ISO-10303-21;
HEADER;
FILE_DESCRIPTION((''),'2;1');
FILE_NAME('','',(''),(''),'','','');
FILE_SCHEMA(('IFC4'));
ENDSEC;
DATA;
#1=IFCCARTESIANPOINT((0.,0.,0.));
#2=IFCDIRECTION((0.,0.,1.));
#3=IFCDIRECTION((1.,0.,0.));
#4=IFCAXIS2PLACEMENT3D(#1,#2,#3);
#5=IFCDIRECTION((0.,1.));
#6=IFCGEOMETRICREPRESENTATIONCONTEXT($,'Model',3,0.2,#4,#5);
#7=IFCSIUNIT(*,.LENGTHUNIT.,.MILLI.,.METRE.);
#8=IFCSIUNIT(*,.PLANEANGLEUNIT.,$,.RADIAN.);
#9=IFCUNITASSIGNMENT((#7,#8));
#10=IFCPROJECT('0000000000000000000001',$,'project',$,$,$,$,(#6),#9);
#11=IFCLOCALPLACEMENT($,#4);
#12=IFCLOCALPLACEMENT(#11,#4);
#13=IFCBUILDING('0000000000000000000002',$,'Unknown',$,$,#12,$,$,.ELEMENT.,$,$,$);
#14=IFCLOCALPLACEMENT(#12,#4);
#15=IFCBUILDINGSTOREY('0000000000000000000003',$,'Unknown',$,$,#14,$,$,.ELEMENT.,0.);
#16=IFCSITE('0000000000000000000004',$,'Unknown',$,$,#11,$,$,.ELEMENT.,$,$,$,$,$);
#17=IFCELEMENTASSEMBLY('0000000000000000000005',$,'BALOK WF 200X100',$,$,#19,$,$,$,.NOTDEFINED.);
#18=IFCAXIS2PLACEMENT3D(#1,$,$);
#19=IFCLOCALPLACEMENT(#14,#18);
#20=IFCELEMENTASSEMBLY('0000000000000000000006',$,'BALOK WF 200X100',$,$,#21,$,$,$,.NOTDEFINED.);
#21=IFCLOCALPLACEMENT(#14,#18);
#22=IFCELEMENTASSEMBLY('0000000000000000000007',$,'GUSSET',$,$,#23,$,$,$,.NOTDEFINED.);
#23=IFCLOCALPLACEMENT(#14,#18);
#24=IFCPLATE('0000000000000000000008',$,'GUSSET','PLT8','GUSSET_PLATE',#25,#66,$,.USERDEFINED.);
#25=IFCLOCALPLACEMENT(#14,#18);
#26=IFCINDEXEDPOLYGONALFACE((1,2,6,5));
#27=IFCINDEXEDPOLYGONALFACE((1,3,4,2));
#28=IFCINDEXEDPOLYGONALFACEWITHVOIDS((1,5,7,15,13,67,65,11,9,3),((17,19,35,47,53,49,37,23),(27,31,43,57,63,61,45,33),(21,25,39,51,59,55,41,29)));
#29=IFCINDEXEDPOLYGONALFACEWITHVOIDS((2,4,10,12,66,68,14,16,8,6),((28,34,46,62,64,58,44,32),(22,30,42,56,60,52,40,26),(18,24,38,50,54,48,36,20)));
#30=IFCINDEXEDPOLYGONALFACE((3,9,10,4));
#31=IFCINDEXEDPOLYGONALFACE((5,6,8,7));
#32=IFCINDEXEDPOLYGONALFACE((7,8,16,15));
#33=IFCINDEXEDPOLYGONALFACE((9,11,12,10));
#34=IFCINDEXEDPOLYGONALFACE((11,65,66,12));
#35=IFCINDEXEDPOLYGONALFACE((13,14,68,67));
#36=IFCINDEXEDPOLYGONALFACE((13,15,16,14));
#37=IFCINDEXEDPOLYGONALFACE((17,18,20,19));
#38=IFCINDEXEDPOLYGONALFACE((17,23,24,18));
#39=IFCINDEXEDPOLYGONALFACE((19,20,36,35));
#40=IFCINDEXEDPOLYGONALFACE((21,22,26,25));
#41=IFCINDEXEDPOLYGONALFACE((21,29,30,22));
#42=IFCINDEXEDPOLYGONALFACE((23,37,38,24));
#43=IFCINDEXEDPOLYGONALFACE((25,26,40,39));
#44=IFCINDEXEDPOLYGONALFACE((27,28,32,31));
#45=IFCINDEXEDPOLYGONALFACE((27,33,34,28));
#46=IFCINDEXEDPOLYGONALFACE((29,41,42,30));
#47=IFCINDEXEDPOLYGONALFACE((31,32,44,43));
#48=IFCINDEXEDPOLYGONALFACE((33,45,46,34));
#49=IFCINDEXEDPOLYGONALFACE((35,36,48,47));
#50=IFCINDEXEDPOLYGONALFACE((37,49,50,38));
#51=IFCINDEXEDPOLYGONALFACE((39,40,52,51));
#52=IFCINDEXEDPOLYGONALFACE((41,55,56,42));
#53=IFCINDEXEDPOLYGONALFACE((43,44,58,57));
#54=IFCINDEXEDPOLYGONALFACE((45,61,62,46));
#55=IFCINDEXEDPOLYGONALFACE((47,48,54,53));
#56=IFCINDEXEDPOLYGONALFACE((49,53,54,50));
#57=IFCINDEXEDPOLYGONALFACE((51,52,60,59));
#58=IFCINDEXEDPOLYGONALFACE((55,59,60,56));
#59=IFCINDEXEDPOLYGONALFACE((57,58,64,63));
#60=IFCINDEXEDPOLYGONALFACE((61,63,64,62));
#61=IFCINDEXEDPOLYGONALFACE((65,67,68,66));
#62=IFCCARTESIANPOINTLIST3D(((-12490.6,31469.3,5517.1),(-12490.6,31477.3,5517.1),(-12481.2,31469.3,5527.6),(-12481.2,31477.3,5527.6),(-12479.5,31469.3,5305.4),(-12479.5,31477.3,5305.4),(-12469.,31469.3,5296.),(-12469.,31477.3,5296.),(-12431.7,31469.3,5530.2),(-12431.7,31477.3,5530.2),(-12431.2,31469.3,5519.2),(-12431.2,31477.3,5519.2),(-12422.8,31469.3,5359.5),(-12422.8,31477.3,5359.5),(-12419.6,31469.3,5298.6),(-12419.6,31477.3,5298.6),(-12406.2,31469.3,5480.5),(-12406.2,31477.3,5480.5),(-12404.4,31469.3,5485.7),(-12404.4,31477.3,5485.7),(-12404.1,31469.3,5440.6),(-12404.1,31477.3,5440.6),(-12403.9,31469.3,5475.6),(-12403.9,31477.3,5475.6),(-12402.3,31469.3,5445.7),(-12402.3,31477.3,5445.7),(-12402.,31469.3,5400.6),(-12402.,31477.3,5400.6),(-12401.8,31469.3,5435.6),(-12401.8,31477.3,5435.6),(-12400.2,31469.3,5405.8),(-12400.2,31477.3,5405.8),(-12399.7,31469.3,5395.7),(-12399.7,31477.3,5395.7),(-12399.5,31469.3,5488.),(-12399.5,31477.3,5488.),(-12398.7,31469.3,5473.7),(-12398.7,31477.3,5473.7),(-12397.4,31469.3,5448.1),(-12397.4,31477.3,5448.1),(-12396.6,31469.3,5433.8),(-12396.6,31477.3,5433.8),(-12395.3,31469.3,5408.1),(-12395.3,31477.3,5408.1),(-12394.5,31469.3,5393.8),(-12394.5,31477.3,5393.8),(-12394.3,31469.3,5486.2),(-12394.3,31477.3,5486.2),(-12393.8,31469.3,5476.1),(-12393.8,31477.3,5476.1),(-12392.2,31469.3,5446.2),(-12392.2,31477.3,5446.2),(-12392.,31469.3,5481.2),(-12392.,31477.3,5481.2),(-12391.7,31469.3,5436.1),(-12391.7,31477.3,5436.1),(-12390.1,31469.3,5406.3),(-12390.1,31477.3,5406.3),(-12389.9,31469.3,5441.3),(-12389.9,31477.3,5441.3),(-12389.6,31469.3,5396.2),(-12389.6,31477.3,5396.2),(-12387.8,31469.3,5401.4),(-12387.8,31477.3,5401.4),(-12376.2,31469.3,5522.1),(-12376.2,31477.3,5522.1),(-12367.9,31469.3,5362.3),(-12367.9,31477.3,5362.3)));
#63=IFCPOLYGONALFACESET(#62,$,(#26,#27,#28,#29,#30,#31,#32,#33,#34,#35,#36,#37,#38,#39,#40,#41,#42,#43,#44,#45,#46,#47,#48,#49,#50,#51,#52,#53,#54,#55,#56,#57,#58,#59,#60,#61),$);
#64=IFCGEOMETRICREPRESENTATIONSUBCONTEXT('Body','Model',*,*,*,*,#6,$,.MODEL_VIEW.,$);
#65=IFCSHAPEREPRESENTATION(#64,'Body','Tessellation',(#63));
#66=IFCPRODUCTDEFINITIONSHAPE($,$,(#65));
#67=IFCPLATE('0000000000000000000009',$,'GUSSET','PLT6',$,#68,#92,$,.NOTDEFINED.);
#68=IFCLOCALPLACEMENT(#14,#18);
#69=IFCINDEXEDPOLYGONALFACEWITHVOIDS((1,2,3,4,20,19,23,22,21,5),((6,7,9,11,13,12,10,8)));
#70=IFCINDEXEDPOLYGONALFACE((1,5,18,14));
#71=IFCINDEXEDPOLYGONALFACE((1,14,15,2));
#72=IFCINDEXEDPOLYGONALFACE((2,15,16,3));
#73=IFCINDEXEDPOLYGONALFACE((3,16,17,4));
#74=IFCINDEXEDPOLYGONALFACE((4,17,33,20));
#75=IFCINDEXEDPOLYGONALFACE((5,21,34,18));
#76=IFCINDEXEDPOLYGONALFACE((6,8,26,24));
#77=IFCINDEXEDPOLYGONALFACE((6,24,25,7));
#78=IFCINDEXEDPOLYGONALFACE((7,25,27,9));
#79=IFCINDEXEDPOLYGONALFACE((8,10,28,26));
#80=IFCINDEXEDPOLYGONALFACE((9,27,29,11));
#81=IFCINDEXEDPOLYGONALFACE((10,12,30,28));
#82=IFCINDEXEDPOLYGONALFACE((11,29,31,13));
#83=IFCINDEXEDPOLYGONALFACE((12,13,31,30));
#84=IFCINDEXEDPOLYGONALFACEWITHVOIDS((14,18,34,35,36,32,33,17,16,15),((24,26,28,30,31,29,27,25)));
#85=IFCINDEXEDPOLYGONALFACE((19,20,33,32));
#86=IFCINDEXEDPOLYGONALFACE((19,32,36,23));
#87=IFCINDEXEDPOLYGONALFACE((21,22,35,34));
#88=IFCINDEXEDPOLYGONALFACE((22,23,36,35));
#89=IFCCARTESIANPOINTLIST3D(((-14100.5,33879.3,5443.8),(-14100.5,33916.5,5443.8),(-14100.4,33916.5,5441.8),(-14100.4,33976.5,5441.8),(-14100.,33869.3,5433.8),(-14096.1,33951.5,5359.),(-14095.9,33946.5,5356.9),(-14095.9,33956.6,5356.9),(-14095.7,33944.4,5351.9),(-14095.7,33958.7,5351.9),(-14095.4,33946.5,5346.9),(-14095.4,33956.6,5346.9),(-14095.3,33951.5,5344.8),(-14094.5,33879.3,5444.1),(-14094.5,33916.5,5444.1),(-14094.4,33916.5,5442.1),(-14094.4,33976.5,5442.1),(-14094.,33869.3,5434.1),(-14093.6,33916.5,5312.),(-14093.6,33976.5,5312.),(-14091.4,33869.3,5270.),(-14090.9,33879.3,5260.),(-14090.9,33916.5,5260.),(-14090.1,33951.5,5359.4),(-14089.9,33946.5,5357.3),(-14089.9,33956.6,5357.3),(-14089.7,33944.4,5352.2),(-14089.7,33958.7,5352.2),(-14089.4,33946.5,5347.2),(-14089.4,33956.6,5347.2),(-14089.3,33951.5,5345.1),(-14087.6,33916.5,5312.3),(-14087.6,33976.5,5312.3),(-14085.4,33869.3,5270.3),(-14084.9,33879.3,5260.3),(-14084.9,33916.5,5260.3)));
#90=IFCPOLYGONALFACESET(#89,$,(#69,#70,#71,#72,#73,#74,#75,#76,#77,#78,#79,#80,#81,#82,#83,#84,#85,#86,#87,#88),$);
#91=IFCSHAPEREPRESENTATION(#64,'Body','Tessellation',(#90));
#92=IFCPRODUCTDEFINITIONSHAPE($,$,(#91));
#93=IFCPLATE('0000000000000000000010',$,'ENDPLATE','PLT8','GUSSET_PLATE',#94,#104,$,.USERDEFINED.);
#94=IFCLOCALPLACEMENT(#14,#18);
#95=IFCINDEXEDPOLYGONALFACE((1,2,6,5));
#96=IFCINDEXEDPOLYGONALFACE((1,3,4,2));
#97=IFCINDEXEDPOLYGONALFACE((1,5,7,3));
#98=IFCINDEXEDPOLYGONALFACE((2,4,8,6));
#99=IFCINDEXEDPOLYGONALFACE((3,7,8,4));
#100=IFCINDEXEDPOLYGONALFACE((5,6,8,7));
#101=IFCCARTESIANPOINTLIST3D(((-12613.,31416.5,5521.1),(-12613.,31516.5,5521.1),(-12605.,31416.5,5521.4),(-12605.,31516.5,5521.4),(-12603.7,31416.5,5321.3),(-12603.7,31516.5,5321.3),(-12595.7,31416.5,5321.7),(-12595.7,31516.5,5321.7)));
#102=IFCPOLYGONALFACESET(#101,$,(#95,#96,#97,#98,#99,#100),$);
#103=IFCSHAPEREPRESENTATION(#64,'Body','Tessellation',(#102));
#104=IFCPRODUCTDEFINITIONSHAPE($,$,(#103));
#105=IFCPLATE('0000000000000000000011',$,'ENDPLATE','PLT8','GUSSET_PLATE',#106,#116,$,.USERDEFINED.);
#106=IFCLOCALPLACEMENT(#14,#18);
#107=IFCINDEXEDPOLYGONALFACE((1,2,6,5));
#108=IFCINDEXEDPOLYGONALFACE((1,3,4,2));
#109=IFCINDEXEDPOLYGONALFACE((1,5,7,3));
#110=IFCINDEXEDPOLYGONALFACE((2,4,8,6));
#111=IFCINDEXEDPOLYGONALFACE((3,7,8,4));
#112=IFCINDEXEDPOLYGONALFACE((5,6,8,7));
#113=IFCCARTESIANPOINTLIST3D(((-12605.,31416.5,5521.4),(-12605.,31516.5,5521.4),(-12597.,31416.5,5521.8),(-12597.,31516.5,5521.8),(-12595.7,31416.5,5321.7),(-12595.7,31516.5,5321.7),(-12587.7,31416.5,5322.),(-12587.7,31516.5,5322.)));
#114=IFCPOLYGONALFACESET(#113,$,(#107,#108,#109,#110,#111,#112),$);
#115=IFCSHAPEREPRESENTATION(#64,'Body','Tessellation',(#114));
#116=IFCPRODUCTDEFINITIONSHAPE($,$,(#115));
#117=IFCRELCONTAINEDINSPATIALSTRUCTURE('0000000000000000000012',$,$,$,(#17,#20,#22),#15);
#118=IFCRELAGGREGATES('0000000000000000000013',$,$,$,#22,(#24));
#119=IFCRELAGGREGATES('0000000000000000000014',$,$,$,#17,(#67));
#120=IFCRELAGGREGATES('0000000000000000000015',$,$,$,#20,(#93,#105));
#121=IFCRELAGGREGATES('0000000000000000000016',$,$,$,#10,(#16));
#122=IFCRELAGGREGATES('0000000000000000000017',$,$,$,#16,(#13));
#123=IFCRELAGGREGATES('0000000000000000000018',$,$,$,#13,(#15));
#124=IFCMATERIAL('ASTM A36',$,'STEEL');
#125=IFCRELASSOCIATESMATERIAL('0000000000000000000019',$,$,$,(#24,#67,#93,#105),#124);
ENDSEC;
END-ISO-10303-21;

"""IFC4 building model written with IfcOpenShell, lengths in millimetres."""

from ifc_helpers import new_model, si_unit, direction, frame, origin_with_axes, place, context, subcontext, project, spatial, line, indexed_curve, outline, extrude, material, element, aggregate, save


model = new_model("IFC4")

# Units and contexts
model_context = context("Model", 3, precision=0.2, world=origin_with_axes(), true_north=direction((0.0, 1.0)))
body_context = subcontext(model_context, "Body", "Model", "MODEL_VIEW")
ifc_project = project(units=[si_unit("LENGTHUNIT", "METRE", prefix="MILLI"), si_unit("PLANEANGLEUNIT", "RADIAN")], contexts=[model_context])

# Site, building, storey
site_placement = place(None, origin_with_axes())
site = spatial("IfcSite", under=ifc_project, at=site_placement, Name="Unknown", CompositionType="ELEMENT")
building_placement = place(site_placement, origin_with_axes())
building = spatial("IfcBuilding", under=site, at=building_placement, Name="Unknown", CompositionType="ELEMENT")
storey_placement = place(building_placement, origin_with_axes())
storey = spatial("IfcBuildingStorey", under=building, at=storey_placement, Name="Unknown", CompositionType="ELEMENT", Elevation=0.0)

# Element assemblies
assembly_1_placement = place(storey_placement, frame((-12608.3, 33866.5, 5421.2), z_axis=(0.0, 1.0, 0.0), x_axis=(-0.998912, 0.0, -0.046636)))
assembly_1 = element("IfcElementAssembly", 1, at=assembly_1_placement, inside=storey, Name="BALOK WF 200X100", PredefinedType="NOTDEFINED")
assembly_2_placement = place(storey_placement, frame((-12608.3, 31466.5, 5421.2), z_axis=(0.0, 1.0, 0.0), x_axis=(-0.998912, 0.0, -0.046636)))
assembly_2 = element("IfcElementAssembly", 2, at=assembly_2_placement, inside=storey, Name="BALOK WF 200X100", PredefinedType="NOTDEFINED")

# Shared definitions
ifc_material_1 = material(Name="ASTM A36", Category="STEEL")

# Element assembly, plate, voiding features
assembly_3_placement = place(storey_placement, frame((-12491.1, 31473.3, 5527.1), z_axis=(0.0, 1.0, 0.0), x_axis=(0.99863, 0.0, 0.052336)))
assembly_3 = element("IfcElementAssembly", 3, at=assembly_3_placement, inside=storey, Name="GUSSET", PredefinedType="NOTDEFINED")
plate_1_placement = place(assembly_3_placement, origin_with_axes())
plate_1 = element("IfcPlate", 4, at=plate_1_placement, material=ifc_material_1, Name="GUSSET", Description="PLT8", ObjectType="GUSSET_PLATE", PredefinedType="USERDEFINED", context=body_context, shape_type="SolidModel", body=[
    extrude(outline(indexed_curve([(0.0, 0.0), (59.5, 0.0), (59.5, 11.0), (114.5, 11.0), (114.5, 171.0), (59.5, 171.0), (59.5, 232.0), (0.0, 232.0)], segments=[line(1, 2, 3, 4, 5, 6, 7, 8, 1)])), frame((0.0, 0.0, 4.0), z_axis=(0.0, 0.0, 1.0), x_axis=(1.0, 0.0, 0.0)), (0.0, 0.0, -1.0), 8.0),
])
voiding_feature_1_placement = place(plate_1_placement, frame((10.0, 0.0, 0.0), z_axis=(0.0, 0.0, 1.0), x_axis=(-0.707107, 0.707107, 0.0)))
element("IfcVoidingFeature", 5, at=voiding_feature_1_placement, cuts=plate_1, Name="SLAB", PredefinedType="HOLE", context=body_context, shape_type="SolidModel", body=[
    extrude(outline(indexed_curve([(0.0, 0.0), (14.1, 0.0), (7.1, 7.1)], segments=[line(1, 2, 3, 1)])), frame((0.0, 0.0, 4.0), z_axis=(0.0, 0.0, 1.0), x_axis=(1.0, 0.0, 0.0)), (0.0, 0.0, -1.0), 8.0),
])
voiding_feature_2_placement = place(plate_1_placement, frame((0.0, 222.0, 0.0), z_axis=(0.0, 0.0, 1.0), x_axis=(0.707107, 0.707107, 0.0)))
element("IfcVoidingFeature", 6, at=voiding_feature_2_placement, cuts=plate_1, Name="SLAB", PredefinedType="HOLE", context=body_context, shape_type="SolidModel", body=[
    extrude(outline(indexed_curve([(0.0, 0.0), (14.1, 0.0), (7.1, 7.1)], segments=[line(1, 2, 3, 1)])), frame((0.0, 0.0, 4.0), z_axis=(0.0, 0.0, 1.0), x_axis=(1.0, 0.0, 0.0)), (0.0, 0.0, -1.0), 8.0),
])
voiding_feature_3_placement = place(plate_1_placement, frame((89.5, 91.0, -4.5), z_axis=(-1.0, 0.0, 0.0), x_axis=(0.0, 0.0, 1.0)))
element("IfcVoidingFeature", 7, at=voiding_feature_3_placement, cuts=plate_1, Name="BEAM", PredefinedType="HOLE", context=body_context, shape_type="SolidModel", body=[
    extrude(outline(indexed_curve([(7.1, 0.0), (5.1, 5.1), (0.0, 7.1), (-5.1, 5.1), (-7.1, 0.0), (-5.1, -5.1), (0.0, -7.1), (5.1, -5.1)], segments=[line(1, 2, 3, 4, 5, 6, 7, 8, 1)])), frame((0.0, 0.0, 0.0), z_axis=(-1.0, 0.0, 0.0), x_axis=(0.0, 0.0, 1.0)), (0.0, 0.0, -1.0), 9.0),
])
voiding_feature_4_placement = place(plate_1_placement, frame((89.5, 131.0, -4.5), z_axis=(-1.0, 0.0, 0.0), x_axis=(0.0, 0.0, 1.0)))
element("IfcVoidingFeature", 8, at=voiding_feature_4_placement, cuts=plate_1, Name="BEAM", PredefinedType="HOLE", context=body_context, shape_type="SolidModel", body=[
    extrude(outline(indexed_curve([(7.1, 0.0), (5.1, 5.1), (0.0, 7.1), (-5.1, 5.1), (-7.1, 0.0), (-5.1, -5.1), (0.0, -7.1), (5.1, -5.1)], segments=[line(1, 2, 3, 4, 5, 6, 7, 8, 1)])), frame((0.0, 0.0, 0.0), z_axis=(-1.0, 0.0, 0.0), x_axis=(0.0, 0.0, 1.0)), (0.0, 0.0, -1.0), 9.0),
])
voiding_feature_5_placement = place(plate_1_placement, frame((89.5, 51.0, -4.5), z_axis=(-1.0, 0.0, 0.0), x_axis=(0.0, 0.0, 1.0)))
element("IfcVoidingFeature", 9, at=voiding_feature_5_placement, cuts=plate_1, Name="BEAM", PredefinedType="HOLE", context=body_context, shape_type="SolidModel", body=[
    extrude(outline(indexed_curve([(7.1, 0.0), (5.1, 5.1), (0.0, 7.1), (-5.1, 5.1), (-7.1, 0.0), (-5.1, -5.1), (0.0, -7.1), (5.1, -5.1)], segments=[line(1, 2, 3, 4, 5, 6, 7, 8, 1)])), frame((0.0, 0.0, 0.0), z_axis=(-1.0, 0.0, 0.0), x_axis=(0.0, 0.0, 1.0)), (0.0, 0.0, -1.0), 9.0),
])
aggregate(assembly_3, [plate_1])

# Plate, voiding features
plate_2_placement = place(assembly_1_placement, frame((1486.5, 92.2, 2.8), z_axis=(0.999984, -0.005707, 0.0), x_axis=(0.0, 0.0, 1.0)))
plate_2 = element("IfcPlate", 10, at=plate_2_placement, material=ifc_material_1, Name="GUSSET", Description="PLT6", PredefinedType="NOTDEFINED", context=body_context, shape_type="SolidModel", body=[
    extrude(outline(indexed_curve([(0.0, 0.0), (47.2, 0.0), (47.2, 2.0), (107.3, 2.0), (107.3, 132.0), (47.2, 132.0), (47.2, 184.0), (0.0, 184.0)], segments=[line(1, 2, 3, 4, 5, 6, 7, 8, 1)])), frame((0.0, 0.0, 3.0), z_axis=(0.0, 0.0, 1.0), x_axis=(1.0, 0.0, 0.0)), (0.0, 0.0, -1.0), 6.0),
])
voiding_feature_6_placement = place(plate_2_placement, frame((10.0, 0.0, 0.0), z_axis=(0.0, 0.0, 1.0), x_axis=(-0.707107, 0.707107, 0.0)))
element("IfcVoidingFeature", 11, at=voiding_feature_6_placement, cuts=plate_2, Name="SLAB", PredefinedType="HOLE", context=body_context, shape_type="SolidModel", body=[
    extrude(outline(indexed_curve([(0.0, 0.0), (14.1, 0.0), (7.1, 7.1)], segments=[line(1, 2, 3, 1)])), frame((0.0, 0.0, 3.0), z_axis=(0.0, 0.0, 1.0), x_axis=(1.0, 0.0, 0.0)), (0.0, 0.0, -1.0), 6.0),
])
voiding_feature_7_placement = place(plate_2_placement, frame((0.0, 174.0, 0.0), z_axis=(0.0, 0.0, 1.0), x_axis=(0.707107, 0.707107, 0.0)))
element("IfcVoidingFeature", 12, at=voiding_feature_7_placement, cuts=plate_2, Name="SLAB", PredefinedType="HOLE", context=body_context, shape_type="SolidModel", body=[
    extrude(outline(indexed_curve([(0.0, 0.0), (14.1, 0.0), (7.1, 7.1)], segments=[line(1, 2, 3, 1)])), frame((0.0, 0.0, 3.0), z_axis=(0.0, 0.0, 1.0), x_axis=(1.0, 0.0, 0.0)), (0.0, 0.0, -1.0), 6.0),
])
voiding_feature_8_placement = place(plate_2_placement, frame((82.3, 92.0, -3.5), z_axis=(-1.0, 0.0, 0.0), x_axis=(0.0, 0.0, 1.0)))
element("IfcVoidingFeature", 13, at=voiding_feature_8_placement, cuts=plate_2, Name="BEAM", PredefinedType="HOLE", context=body_context, shape_type="SolidModel", body=[
    extrude(outline(indexed_curve([(7.1, 0.0), (5.1, 5.1), (0.0, 7.1), (-5.1, 5.1), (-7.1, 0.0), (-5.1, -5.1), (0.0, -7.1), (5.1, -5.1)], segments=[line(1, 2, 3, 4, 5, 6, 7, 8, 1)])), frame((0.0, 0.0, 0.0), z_axis=(-1.0, 0.0, 0.0), x_axis=(0.0, 0.0, 1.0)), (0.0, 0.0, -1.0), 7.0),
])

# Plates
plate_3_placement = place(assembly_2_placement, frame((-4.0, 100.0, 50.0), z_axis=(-1.0, -0.000001, 0.0), x_axis=(0.0, 0.0, -1.0)))
plate_3 = element("IfcPlate", 14, at=plate_3_placement, material=ifc_material_1, Name="ENDPLATE", Description="PLT8", ObjectType="GUSSET_PLATE", PredefinedType="USERDEFINED", context=body_context, shape_type="SolidModel", body=[
    extrude(outline(indexed_curve([(0.0, 0.0), (100.0, 0.0), (100.0, 200.0), (0.0, 200.0)], segments=[line(1, 2, 3, 4, 1)])), frame((0.0, 0.0, 4.0), z_axis=(0.0, 0.0, 1.0), x_axis=(1.0, 0.0, 0.0)), (0.0, 0.0, -1.0), 8.0),
])
plate_4_placement = place(assembly_2_placement, frame((-12.0, 100.0, 50.0), z_axis=(-1.0, -0.000001, 0.0), x_axis=(0.0, 0.0, -1.0)))
plate_4 = element("IfcPlate", 15, at=plate_4_placement, material=ifc_material_1, Name="ENDPLATE", Description="PLT8", ObjectType="GUSSET_PLATE", PredefinedType="USERDEFINED", context=body_context, shape_type="SolidModel", body=[
    extrude(outline(indexed_curve([(0.0, 0.0), (100.0, 0.0), (100.0, 200.0), (0.0, 200.0)], segments=[line(1, 2, 3, 4, 1)])), frame((0.0, 0.0, 4.0), z_axis=(0.0, 0.0, 1.0), x_axis=(1.0, 0.0, 0.0)), (0.0, 0.0, -1.0), 8.0),
])

aggregate(assembly_1, [plate_2])
aggregate(assembly_2, [plate_3, plate_4])

save(model, "model.ifc")
